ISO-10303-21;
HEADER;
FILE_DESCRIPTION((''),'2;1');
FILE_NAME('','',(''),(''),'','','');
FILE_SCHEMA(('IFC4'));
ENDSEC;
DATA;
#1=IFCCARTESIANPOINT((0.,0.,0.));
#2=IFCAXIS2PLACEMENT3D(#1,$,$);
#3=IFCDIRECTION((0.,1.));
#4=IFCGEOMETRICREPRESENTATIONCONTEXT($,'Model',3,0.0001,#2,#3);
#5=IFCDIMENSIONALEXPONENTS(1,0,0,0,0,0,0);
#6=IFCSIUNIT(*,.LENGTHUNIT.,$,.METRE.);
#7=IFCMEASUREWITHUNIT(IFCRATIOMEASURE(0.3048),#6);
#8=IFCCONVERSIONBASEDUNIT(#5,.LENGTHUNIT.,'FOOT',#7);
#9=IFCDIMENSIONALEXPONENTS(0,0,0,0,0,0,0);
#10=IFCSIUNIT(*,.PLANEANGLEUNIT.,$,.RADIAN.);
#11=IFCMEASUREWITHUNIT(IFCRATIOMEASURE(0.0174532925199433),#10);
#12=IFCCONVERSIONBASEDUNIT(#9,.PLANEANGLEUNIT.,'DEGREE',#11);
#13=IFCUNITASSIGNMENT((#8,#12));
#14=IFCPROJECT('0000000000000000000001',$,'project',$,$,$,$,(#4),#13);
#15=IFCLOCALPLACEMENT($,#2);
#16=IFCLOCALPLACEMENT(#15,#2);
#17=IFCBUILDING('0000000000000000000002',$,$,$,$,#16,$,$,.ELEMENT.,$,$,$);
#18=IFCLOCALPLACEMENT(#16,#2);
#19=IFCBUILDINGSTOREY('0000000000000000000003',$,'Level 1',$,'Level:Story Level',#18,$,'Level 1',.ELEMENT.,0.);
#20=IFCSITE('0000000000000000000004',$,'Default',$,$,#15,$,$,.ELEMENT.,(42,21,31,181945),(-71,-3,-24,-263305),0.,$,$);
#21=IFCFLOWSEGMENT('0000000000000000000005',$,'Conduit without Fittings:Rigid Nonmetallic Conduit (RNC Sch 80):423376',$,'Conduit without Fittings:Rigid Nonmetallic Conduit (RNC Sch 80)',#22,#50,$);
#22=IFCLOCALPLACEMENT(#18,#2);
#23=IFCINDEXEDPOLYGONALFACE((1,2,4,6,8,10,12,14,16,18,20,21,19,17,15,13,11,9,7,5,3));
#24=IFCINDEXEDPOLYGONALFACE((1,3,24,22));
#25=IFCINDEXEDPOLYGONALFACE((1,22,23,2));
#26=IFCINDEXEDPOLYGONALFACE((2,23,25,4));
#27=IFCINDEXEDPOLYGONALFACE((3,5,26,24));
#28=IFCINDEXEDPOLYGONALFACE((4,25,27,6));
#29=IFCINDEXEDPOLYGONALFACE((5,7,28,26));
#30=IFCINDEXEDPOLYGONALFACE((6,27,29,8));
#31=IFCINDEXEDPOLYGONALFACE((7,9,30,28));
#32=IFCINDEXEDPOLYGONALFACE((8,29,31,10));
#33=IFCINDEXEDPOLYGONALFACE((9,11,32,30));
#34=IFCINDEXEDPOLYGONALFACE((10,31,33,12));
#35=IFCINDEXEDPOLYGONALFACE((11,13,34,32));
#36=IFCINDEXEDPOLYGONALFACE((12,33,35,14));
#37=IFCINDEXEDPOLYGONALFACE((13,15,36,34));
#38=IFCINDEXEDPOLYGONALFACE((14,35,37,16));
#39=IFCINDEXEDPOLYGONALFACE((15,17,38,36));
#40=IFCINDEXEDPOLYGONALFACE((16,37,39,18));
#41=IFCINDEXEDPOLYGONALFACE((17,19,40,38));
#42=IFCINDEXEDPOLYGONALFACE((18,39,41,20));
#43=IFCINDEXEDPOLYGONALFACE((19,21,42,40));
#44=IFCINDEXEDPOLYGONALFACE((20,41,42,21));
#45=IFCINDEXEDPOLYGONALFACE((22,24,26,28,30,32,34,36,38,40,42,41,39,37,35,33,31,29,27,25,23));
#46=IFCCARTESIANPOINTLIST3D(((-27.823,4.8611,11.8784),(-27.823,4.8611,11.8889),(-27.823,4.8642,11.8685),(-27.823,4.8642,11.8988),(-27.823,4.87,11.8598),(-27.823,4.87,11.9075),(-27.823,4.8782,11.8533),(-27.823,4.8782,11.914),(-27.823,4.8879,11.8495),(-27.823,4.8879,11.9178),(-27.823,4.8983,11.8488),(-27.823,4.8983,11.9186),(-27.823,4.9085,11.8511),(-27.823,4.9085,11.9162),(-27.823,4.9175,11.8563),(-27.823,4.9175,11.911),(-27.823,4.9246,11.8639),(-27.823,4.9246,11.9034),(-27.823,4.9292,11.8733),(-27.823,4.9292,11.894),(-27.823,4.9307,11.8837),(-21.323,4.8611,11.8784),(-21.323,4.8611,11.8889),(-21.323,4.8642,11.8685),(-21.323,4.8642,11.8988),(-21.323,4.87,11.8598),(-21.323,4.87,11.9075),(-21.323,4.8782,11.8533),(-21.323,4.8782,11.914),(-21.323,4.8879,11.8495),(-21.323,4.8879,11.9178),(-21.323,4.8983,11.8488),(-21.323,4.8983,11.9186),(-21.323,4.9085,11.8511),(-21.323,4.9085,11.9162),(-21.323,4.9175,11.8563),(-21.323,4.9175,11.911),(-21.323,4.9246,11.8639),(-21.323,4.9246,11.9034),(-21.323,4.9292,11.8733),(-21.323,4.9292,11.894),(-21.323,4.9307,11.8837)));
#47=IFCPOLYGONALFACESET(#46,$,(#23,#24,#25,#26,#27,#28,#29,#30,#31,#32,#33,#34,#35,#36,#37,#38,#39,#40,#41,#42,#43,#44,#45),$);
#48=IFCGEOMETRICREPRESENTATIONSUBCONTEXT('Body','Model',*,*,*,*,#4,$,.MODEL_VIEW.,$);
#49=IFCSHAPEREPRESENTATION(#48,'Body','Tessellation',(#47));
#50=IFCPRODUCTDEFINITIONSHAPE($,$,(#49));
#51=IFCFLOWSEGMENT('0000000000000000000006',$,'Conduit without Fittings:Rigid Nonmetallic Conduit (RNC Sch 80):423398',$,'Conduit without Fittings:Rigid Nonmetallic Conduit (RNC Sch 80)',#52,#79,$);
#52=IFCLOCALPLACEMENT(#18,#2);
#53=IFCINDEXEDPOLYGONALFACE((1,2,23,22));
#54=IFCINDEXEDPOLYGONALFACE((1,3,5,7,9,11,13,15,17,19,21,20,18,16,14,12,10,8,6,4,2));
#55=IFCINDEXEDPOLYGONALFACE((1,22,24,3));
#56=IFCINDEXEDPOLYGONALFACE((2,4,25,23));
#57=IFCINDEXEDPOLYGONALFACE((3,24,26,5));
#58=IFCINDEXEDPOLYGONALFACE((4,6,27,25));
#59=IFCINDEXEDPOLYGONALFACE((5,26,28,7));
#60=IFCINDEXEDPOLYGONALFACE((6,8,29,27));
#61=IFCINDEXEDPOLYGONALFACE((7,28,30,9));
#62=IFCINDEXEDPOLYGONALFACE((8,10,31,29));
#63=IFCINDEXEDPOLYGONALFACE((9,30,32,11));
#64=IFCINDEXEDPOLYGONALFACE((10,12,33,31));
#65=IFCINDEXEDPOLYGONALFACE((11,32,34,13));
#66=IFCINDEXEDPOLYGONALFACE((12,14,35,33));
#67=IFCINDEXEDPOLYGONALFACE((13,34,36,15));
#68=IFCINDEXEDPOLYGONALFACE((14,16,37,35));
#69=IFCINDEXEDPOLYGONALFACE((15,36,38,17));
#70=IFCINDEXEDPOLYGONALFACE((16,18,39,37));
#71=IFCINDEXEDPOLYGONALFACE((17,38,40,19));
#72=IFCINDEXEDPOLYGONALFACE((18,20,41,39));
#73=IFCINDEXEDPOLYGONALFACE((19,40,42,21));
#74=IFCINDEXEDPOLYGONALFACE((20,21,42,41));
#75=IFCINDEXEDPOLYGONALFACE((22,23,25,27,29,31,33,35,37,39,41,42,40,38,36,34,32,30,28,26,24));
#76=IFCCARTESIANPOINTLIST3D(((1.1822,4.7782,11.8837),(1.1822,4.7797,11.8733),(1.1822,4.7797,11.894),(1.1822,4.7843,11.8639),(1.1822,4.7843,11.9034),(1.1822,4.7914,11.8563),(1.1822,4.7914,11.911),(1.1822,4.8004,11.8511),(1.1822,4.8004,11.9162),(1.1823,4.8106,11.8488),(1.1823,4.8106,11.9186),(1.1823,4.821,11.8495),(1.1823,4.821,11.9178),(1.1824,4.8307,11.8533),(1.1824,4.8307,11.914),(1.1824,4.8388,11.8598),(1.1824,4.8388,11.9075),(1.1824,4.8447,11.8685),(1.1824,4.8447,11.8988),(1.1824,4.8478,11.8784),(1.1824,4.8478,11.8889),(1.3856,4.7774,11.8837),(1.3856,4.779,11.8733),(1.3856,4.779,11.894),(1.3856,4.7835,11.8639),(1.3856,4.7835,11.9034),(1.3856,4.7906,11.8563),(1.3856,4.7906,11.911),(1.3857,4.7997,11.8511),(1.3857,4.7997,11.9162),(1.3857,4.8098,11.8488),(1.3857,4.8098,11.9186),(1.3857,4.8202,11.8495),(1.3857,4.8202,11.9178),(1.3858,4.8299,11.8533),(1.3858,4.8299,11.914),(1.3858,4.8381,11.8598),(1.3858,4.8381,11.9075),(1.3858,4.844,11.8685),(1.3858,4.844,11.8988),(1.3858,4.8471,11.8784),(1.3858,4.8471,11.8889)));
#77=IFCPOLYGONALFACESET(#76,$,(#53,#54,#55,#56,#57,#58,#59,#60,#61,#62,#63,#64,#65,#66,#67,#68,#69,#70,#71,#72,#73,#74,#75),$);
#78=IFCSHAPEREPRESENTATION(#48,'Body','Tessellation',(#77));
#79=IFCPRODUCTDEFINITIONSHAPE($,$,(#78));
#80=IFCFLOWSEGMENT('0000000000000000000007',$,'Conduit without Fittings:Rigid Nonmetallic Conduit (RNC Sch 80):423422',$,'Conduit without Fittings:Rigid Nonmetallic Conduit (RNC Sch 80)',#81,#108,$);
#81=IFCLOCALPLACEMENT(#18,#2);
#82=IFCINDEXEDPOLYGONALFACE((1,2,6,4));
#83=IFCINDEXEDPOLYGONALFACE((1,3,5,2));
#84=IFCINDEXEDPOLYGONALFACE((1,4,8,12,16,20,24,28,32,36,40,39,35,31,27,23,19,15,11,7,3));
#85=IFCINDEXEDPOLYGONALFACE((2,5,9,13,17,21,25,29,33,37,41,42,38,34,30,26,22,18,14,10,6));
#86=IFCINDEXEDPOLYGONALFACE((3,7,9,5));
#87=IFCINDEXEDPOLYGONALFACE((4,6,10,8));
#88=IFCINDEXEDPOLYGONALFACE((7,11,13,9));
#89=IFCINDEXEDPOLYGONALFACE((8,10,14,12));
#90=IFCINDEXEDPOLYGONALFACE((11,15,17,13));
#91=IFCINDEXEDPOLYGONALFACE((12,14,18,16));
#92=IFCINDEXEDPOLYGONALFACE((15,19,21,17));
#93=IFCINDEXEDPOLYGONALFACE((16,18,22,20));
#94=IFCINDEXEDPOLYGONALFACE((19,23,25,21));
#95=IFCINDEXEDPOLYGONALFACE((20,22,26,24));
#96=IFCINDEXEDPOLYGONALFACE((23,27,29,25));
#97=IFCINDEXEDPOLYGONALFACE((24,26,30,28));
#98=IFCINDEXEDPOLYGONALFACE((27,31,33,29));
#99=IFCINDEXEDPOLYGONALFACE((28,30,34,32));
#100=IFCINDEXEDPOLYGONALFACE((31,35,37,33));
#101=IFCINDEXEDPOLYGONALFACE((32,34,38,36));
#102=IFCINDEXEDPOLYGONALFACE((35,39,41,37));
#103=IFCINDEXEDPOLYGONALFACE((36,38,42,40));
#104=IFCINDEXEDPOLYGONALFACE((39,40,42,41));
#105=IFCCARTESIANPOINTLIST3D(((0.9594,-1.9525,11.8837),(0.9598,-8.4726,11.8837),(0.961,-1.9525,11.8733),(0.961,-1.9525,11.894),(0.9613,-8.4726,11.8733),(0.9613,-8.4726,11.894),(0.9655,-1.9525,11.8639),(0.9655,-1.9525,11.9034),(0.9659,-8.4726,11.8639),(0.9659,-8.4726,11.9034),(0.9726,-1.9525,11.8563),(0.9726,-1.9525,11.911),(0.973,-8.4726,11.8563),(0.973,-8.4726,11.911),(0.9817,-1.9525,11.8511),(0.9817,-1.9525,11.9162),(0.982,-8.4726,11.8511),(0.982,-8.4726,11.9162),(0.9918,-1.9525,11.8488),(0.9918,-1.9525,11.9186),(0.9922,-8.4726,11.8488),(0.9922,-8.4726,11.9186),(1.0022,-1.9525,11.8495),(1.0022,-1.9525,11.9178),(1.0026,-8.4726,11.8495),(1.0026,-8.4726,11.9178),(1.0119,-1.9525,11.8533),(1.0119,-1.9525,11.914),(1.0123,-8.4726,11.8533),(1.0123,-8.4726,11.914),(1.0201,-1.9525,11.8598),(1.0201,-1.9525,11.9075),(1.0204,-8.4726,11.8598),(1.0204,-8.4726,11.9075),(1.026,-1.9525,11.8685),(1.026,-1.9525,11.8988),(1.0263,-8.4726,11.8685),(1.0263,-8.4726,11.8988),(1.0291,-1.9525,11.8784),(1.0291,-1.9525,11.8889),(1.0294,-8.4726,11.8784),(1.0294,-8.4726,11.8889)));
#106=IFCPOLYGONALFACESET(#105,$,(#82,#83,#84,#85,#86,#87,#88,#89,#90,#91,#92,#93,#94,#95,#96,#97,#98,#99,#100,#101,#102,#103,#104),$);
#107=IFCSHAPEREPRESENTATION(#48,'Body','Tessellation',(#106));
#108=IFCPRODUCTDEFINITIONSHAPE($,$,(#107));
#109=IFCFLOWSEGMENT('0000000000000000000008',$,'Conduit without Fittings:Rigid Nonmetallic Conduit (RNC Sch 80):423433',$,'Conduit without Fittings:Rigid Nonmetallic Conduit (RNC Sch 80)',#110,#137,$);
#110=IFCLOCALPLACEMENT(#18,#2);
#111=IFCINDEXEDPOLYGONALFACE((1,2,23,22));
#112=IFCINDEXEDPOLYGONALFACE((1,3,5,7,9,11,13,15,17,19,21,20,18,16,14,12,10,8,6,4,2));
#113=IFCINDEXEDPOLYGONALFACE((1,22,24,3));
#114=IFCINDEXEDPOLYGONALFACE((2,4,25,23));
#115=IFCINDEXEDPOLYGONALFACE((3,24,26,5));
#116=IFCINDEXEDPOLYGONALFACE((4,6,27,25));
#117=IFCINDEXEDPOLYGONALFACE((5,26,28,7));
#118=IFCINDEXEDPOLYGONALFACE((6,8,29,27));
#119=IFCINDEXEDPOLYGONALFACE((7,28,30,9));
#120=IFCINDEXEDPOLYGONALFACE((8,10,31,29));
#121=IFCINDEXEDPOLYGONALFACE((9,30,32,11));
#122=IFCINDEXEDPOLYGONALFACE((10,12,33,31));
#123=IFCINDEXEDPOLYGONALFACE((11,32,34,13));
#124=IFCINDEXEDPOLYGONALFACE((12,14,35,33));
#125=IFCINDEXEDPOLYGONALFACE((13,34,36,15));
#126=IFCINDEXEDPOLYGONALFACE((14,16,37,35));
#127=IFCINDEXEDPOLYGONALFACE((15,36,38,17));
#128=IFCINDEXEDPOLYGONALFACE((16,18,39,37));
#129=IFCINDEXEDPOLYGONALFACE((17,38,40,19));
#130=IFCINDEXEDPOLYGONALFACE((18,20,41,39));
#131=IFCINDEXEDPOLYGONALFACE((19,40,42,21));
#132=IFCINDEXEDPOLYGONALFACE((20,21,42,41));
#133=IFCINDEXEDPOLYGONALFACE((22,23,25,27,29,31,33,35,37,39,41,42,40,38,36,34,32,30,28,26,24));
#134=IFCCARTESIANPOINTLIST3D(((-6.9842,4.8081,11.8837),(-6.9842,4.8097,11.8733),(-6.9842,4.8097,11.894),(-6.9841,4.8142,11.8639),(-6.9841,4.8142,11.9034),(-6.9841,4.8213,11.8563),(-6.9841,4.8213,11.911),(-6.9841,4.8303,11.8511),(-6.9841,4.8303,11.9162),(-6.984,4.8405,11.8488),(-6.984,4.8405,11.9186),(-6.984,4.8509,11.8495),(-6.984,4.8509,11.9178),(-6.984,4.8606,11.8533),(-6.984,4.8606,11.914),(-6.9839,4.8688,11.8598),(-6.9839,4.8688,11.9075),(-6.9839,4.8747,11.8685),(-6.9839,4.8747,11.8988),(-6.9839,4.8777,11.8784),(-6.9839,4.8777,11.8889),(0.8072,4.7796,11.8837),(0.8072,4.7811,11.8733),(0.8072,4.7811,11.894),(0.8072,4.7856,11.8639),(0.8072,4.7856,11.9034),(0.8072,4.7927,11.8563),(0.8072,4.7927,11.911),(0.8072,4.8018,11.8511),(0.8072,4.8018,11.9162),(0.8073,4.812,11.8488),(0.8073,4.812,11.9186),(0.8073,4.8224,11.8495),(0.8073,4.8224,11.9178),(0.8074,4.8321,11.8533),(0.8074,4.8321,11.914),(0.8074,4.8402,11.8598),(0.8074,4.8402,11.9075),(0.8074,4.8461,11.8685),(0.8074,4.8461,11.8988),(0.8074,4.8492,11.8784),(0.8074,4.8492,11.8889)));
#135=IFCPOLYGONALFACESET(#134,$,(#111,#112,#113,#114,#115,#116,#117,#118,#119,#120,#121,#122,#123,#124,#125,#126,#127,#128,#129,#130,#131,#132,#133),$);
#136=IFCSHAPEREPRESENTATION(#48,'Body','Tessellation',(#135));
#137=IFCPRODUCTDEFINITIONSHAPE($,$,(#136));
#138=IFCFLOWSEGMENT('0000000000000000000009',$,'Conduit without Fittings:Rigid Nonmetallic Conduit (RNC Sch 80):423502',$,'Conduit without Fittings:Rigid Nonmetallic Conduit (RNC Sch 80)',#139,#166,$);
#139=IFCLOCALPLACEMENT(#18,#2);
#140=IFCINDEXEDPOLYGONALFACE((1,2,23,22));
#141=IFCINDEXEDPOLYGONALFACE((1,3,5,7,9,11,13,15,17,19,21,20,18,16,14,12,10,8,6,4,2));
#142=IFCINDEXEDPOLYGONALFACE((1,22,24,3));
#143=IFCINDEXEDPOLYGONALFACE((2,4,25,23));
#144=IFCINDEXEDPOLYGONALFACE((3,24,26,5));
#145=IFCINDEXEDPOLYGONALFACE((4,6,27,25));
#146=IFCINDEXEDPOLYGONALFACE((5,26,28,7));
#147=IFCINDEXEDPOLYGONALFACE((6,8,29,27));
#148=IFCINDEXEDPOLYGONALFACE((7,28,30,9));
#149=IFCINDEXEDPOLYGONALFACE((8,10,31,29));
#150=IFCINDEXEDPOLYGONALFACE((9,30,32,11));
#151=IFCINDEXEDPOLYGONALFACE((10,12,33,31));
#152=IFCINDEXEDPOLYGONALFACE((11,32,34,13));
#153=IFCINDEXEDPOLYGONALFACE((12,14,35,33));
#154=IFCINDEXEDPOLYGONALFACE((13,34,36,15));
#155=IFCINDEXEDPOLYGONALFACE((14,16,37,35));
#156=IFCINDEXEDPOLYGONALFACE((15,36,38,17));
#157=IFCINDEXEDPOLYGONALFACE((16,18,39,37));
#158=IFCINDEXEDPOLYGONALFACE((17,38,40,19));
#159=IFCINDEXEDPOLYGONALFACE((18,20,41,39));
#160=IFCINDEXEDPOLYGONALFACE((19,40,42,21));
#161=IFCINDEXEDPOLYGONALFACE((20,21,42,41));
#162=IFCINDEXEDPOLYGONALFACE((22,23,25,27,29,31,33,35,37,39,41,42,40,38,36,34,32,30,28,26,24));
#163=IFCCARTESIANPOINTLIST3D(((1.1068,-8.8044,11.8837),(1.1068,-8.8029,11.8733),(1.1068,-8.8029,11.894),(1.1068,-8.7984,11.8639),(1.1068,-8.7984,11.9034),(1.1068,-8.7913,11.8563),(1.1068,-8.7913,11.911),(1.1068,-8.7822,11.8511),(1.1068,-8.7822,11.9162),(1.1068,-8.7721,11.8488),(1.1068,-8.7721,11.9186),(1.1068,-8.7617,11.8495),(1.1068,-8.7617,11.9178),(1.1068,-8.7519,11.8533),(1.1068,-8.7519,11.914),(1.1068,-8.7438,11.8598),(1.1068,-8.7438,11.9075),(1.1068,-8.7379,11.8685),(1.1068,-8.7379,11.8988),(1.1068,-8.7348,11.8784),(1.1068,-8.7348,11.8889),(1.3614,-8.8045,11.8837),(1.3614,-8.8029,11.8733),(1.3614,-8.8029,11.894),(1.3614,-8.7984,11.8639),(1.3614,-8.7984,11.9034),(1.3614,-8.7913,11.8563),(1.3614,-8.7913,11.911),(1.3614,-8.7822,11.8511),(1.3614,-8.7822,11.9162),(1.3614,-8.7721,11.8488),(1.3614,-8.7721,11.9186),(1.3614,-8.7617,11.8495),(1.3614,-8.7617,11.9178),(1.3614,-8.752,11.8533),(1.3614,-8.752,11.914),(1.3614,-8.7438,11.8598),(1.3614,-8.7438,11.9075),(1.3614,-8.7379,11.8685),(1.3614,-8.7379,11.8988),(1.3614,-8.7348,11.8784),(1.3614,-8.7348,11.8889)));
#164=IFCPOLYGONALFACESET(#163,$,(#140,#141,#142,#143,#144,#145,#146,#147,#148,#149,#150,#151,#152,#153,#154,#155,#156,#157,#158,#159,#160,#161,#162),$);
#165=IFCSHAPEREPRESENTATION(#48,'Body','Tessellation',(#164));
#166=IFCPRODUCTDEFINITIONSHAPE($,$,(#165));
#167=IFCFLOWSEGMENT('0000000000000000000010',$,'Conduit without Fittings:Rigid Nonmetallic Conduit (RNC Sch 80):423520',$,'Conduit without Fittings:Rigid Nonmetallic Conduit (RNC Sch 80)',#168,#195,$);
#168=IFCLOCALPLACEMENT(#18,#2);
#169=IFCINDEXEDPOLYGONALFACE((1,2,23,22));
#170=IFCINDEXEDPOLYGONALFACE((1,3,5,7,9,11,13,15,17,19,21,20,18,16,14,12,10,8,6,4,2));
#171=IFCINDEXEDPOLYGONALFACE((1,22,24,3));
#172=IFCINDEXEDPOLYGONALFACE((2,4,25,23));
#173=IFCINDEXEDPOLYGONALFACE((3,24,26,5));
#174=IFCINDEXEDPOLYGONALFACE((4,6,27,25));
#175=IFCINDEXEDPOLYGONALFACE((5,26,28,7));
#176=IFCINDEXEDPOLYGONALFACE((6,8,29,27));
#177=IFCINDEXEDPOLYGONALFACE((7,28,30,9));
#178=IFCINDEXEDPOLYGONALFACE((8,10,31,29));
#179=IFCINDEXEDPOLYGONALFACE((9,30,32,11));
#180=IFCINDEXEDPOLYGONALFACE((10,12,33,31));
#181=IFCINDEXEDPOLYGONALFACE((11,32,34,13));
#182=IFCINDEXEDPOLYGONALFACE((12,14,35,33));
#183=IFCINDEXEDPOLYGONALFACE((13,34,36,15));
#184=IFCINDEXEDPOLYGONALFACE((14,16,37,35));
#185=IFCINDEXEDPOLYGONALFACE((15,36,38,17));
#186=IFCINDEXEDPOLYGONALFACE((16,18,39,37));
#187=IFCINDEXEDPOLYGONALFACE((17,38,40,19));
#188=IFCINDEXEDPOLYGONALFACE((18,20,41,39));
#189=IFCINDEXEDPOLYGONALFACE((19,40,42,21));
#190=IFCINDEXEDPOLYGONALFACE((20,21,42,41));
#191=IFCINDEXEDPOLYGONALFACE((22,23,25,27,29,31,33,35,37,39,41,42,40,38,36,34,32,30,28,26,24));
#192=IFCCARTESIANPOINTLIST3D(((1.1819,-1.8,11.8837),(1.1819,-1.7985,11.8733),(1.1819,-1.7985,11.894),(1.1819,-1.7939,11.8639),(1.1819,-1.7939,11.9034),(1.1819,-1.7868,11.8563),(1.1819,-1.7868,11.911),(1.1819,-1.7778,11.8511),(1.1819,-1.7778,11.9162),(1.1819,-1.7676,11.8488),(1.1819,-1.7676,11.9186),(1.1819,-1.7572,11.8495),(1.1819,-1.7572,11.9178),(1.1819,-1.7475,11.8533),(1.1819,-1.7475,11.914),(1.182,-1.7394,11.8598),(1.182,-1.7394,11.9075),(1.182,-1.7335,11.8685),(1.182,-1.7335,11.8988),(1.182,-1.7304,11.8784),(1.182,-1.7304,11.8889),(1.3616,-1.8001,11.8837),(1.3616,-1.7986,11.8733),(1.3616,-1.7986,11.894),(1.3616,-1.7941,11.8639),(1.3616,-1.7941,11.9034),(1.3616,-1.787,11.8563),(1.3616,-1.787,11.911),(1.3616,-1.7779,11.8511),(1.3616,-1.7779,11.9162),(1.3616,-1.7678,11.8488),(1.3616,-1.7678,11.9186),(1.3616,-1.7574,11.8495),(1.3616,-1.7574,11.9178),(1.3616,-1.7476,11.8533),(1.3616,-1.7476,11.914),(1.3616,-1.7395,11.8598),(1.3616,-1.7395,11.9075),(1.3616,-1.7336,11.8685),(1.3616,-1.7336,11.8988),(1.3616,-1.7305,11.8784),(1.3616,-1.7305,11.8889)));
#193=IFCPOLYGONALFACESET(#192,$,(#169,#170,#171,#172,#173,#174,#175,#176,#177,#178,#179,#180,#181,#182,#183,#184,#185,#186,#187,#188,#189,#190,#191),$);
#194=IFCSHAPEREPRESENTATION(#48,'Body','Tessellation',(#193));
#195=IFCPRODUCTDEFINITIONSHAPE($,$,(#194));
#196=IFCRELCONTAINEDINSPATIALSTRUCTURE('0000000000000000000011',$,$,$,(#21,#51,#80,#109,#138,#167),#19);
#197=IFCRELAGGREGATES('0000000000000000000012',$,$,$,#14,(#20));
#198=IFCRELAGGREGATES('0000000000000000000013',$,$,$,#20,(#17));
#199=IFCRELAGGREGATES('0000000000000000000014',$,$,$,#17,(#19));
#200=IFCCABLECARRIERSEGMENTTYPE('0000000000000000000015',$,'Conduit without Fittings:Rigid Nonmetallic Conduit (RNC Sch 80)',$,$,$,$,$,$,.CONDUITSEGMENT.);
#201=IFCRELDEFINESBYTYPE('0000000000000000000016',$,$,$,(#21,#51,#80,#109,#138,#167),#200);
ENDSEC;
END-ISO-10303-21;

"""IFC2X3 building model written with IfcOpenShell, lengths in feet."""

from ifc_helpers import new_model, entity, si_unit, converted_unit, direction, frame, frame_2d, origin, origin_2d_with_axis, place, context, subcontext, project, spatial, circle, extrude, type_object, element, save


model = new_model("IFC2X3")

# Units and contexts
model_context = context("Model", 3, precision=0.0001, world=origin(), true_north=direction((0.0, 1.0)))
body_context = subcontext(model_context, "Body", "Model", "MODEL_VIEW")
ifc_project = project(units=[converted_unit("LENGTHUNIT", "FOOT", entity("IfcRatioMeasure", 0.3048), si_unit("LENGTHUNIT", "METRE"), dimensions=[1, 0, 0, 0, 0, 0, 0]), converted_unit("PLANEANGLEUNIT", "DEGREE", entity("IfcRatioMeasure", 0.0174532925199433), si_unit("PLANEANGLEUNIT", "RADIAN"), dimensions=[0, 0, 0, 0, 0, 0, 0])], contexts=[model_context])

# Site, building, storey
site_placement = place(None, origin())
site = spatial("IfcSite", under=ifc_project, at=site_placement, Name="Default", CompositionType="ELEMENT", RefLatitude=(42, 21, 31, 181945), RefLongitude=(-71, -3, -24, -263305), RefElevation=0.0)
building_placement = place(site_placement, origin())
building = spatial("IfcBuilding", under=site, at=building_placement, CompositionType="ELEMENT")
storey_placement = place(building_placement, origin())
storey = spatial("IfcBuildingStorey", under=building, at=storey_placement, Name="Level 1", ObjectType="Level:Story Level", LongName="Level 1", CompositionType="ELEMENT", Elevation=0.0)

# Flow segments
cable_carrier_segment_type = type_object("IfcCableCarrierSegmentType", Name="Conduit without Fittings:Rigid Nonmetallic Conduit (RNC Sch 80)", PredefinedType="CONDUITSEGMENT")
flow_segment_1_placement = place(storey_placement, origin())
element("IfcFlowSegment", 1, at=flow_segment_1_placement, inside=storey, type_object=cable_carrier_segment_type, Name="Conduit without Fittings:Rigid Nonmetallic Conduit (RNC Sch 80):423376", ObjectType="Conduit without Fittings:Rigid Nonmetallic Conduit (RNC Sch 80)", context=body_context, shape_type="SweptSolid", body=[
    extrude(circle(Radius=0.035, at=frame_2d((0.0, 0.0), x_axis=(1.0, 0.0))), frame((-27.823, 4.8957, 11.8837), z_axis=(1.0, 0.0, 0.0), x_axis=(0.0, 1.0, 0.0)), (0.0, 0.0, 1.0), 6.5),
])
flow_segment_2_placement = place(storey_placement, origin())
element("IfcFlowSegment", 2, at=flow_segment_2_placement, inside=storey, type_object=cable_carrier_segment_type, Name="Conduit without Fittings:Rigid Nonmetallic Conduit (RNC Sch 80):423398", ObjectType="Conduit without Fittings:Rigid Nonmetallic Conduit (RNC Sch 80)", context=body_context, shape_type="SweptSolid", body=[
    extrude(circle(Radius=0.035, at=origin_2d_with_axis()), frame((1.1823, 4.8132, 11.8837), z_axis=(0.999993, -0.003666, 0.0), x_axis=(-0.003666, -0.999993, 0.0)), (0.0, 0.0, 1.0), 0.2034),
])
flow_segment_3_placement = place(storey_placement, origin())
element("IfcFlowSegment", 3, at=flow_segment_3_placement, inside=storey, type_object=cable_carrier_segment_type, Name="Conduit without Fittings:Rigid Nonmetallic Conduit (RNC Sch 80):423422", ObjectType="Conduit without Fittings:Rigid Nonmetallic Conduit (RNC Sch 80)", context=body_context, shape_type="SweptSolid", body=[
    extrude(circle(Radius=0.035, at=frame_2d((0.0, 0.0), x_axis=(1.0, 0.0))), frame((0.9948, -8.4726, 11.8837), z_axis=(-0.000051, 1.0, 0.0), x_axis=(-1.0, -0.000051, 0.0)), (0.0, 0.0, 1.0), 6.5201),
])
flow_segment_4_placement = place(storey_placement, origin())
element("IfcFlowSegment", 4, at=flow_segment_4_placement, inside=storey, type_object=cable_carrier_segment_type, Name="Conduit without Fittings:Rigid Nonmetallic Conduit (RNC Sch 80):423433", ObjectType="Conduit without Fittings:Rigid Nonmetallic Conduit (RNC Sch 80)", context=body_context, shape_type="SweptSolid", body=[
    extrude(circle(Radius=0.035, at=origin_2d_with_axis()), frame((-6.984, 4.8431, 11.8837), z_axis=(0.999993, -0.003666, 0.0), x_axis=(-0.003666, -0.999993, 0.0)), (0.0, 0.0, 1.0), 7.7914),
])
flow_segment_5_placement = place(storey_placement, origin())
element("IfcFlowSegment", 5, at=flow_segment_5_placement, inside=storey, type_object=cable_carrier_segment_type, Name="Conduit without Fittings:Rigid Nonmetallic Conduit (RNC Sch 80):423502", ObjectType="Conduit without Fittings:Rigid Nonmetallic Conduit (RNC Sch 80)", context=body_context, shape_type="SweptSolid", body=[
    extrude(circle(Radius=0.035, at=frame_2d((0.0, 0.0), x_axis=(1.0, 0.0))), frame((1.1068, -8.7694, 11.8837), z_axis=(1.0, -0.000023, 0.0), x_axis=(-0.000023, -1.0, 0.0)), (0.0, 0.0, 1.0), 0.2546),
])
flow_segment_6_placement = place(storey_placement, origin())
element("IfcFlowSegment", 6, at=flow_segment_6_placement, inside=storey, type_object=cable_carrier_segment_type, Name="Conduit without Fittings:Rigid Nonmetallic Conduit (RNC Sch 80):423520", ObjectType="Conduit without Fittings:Rigid Nonmetallic Conduit (RNC Sch 80)", context=body_context, shape_type="SweptSolid", body=[
    extrude(circle(Radius=0.035, at=frame_2d((0.0, 0.0), x_axis=(1.0, 0.0))), frame((1.1819, -1.765, 11.8837), z_axis=(1.0, -0.000741, 0.0), x_axis=(-0.000741, -1.0, 0.0)), (0.0, 0.0, 1.0), 0.1796),
])

save(model, "model.ifc")
